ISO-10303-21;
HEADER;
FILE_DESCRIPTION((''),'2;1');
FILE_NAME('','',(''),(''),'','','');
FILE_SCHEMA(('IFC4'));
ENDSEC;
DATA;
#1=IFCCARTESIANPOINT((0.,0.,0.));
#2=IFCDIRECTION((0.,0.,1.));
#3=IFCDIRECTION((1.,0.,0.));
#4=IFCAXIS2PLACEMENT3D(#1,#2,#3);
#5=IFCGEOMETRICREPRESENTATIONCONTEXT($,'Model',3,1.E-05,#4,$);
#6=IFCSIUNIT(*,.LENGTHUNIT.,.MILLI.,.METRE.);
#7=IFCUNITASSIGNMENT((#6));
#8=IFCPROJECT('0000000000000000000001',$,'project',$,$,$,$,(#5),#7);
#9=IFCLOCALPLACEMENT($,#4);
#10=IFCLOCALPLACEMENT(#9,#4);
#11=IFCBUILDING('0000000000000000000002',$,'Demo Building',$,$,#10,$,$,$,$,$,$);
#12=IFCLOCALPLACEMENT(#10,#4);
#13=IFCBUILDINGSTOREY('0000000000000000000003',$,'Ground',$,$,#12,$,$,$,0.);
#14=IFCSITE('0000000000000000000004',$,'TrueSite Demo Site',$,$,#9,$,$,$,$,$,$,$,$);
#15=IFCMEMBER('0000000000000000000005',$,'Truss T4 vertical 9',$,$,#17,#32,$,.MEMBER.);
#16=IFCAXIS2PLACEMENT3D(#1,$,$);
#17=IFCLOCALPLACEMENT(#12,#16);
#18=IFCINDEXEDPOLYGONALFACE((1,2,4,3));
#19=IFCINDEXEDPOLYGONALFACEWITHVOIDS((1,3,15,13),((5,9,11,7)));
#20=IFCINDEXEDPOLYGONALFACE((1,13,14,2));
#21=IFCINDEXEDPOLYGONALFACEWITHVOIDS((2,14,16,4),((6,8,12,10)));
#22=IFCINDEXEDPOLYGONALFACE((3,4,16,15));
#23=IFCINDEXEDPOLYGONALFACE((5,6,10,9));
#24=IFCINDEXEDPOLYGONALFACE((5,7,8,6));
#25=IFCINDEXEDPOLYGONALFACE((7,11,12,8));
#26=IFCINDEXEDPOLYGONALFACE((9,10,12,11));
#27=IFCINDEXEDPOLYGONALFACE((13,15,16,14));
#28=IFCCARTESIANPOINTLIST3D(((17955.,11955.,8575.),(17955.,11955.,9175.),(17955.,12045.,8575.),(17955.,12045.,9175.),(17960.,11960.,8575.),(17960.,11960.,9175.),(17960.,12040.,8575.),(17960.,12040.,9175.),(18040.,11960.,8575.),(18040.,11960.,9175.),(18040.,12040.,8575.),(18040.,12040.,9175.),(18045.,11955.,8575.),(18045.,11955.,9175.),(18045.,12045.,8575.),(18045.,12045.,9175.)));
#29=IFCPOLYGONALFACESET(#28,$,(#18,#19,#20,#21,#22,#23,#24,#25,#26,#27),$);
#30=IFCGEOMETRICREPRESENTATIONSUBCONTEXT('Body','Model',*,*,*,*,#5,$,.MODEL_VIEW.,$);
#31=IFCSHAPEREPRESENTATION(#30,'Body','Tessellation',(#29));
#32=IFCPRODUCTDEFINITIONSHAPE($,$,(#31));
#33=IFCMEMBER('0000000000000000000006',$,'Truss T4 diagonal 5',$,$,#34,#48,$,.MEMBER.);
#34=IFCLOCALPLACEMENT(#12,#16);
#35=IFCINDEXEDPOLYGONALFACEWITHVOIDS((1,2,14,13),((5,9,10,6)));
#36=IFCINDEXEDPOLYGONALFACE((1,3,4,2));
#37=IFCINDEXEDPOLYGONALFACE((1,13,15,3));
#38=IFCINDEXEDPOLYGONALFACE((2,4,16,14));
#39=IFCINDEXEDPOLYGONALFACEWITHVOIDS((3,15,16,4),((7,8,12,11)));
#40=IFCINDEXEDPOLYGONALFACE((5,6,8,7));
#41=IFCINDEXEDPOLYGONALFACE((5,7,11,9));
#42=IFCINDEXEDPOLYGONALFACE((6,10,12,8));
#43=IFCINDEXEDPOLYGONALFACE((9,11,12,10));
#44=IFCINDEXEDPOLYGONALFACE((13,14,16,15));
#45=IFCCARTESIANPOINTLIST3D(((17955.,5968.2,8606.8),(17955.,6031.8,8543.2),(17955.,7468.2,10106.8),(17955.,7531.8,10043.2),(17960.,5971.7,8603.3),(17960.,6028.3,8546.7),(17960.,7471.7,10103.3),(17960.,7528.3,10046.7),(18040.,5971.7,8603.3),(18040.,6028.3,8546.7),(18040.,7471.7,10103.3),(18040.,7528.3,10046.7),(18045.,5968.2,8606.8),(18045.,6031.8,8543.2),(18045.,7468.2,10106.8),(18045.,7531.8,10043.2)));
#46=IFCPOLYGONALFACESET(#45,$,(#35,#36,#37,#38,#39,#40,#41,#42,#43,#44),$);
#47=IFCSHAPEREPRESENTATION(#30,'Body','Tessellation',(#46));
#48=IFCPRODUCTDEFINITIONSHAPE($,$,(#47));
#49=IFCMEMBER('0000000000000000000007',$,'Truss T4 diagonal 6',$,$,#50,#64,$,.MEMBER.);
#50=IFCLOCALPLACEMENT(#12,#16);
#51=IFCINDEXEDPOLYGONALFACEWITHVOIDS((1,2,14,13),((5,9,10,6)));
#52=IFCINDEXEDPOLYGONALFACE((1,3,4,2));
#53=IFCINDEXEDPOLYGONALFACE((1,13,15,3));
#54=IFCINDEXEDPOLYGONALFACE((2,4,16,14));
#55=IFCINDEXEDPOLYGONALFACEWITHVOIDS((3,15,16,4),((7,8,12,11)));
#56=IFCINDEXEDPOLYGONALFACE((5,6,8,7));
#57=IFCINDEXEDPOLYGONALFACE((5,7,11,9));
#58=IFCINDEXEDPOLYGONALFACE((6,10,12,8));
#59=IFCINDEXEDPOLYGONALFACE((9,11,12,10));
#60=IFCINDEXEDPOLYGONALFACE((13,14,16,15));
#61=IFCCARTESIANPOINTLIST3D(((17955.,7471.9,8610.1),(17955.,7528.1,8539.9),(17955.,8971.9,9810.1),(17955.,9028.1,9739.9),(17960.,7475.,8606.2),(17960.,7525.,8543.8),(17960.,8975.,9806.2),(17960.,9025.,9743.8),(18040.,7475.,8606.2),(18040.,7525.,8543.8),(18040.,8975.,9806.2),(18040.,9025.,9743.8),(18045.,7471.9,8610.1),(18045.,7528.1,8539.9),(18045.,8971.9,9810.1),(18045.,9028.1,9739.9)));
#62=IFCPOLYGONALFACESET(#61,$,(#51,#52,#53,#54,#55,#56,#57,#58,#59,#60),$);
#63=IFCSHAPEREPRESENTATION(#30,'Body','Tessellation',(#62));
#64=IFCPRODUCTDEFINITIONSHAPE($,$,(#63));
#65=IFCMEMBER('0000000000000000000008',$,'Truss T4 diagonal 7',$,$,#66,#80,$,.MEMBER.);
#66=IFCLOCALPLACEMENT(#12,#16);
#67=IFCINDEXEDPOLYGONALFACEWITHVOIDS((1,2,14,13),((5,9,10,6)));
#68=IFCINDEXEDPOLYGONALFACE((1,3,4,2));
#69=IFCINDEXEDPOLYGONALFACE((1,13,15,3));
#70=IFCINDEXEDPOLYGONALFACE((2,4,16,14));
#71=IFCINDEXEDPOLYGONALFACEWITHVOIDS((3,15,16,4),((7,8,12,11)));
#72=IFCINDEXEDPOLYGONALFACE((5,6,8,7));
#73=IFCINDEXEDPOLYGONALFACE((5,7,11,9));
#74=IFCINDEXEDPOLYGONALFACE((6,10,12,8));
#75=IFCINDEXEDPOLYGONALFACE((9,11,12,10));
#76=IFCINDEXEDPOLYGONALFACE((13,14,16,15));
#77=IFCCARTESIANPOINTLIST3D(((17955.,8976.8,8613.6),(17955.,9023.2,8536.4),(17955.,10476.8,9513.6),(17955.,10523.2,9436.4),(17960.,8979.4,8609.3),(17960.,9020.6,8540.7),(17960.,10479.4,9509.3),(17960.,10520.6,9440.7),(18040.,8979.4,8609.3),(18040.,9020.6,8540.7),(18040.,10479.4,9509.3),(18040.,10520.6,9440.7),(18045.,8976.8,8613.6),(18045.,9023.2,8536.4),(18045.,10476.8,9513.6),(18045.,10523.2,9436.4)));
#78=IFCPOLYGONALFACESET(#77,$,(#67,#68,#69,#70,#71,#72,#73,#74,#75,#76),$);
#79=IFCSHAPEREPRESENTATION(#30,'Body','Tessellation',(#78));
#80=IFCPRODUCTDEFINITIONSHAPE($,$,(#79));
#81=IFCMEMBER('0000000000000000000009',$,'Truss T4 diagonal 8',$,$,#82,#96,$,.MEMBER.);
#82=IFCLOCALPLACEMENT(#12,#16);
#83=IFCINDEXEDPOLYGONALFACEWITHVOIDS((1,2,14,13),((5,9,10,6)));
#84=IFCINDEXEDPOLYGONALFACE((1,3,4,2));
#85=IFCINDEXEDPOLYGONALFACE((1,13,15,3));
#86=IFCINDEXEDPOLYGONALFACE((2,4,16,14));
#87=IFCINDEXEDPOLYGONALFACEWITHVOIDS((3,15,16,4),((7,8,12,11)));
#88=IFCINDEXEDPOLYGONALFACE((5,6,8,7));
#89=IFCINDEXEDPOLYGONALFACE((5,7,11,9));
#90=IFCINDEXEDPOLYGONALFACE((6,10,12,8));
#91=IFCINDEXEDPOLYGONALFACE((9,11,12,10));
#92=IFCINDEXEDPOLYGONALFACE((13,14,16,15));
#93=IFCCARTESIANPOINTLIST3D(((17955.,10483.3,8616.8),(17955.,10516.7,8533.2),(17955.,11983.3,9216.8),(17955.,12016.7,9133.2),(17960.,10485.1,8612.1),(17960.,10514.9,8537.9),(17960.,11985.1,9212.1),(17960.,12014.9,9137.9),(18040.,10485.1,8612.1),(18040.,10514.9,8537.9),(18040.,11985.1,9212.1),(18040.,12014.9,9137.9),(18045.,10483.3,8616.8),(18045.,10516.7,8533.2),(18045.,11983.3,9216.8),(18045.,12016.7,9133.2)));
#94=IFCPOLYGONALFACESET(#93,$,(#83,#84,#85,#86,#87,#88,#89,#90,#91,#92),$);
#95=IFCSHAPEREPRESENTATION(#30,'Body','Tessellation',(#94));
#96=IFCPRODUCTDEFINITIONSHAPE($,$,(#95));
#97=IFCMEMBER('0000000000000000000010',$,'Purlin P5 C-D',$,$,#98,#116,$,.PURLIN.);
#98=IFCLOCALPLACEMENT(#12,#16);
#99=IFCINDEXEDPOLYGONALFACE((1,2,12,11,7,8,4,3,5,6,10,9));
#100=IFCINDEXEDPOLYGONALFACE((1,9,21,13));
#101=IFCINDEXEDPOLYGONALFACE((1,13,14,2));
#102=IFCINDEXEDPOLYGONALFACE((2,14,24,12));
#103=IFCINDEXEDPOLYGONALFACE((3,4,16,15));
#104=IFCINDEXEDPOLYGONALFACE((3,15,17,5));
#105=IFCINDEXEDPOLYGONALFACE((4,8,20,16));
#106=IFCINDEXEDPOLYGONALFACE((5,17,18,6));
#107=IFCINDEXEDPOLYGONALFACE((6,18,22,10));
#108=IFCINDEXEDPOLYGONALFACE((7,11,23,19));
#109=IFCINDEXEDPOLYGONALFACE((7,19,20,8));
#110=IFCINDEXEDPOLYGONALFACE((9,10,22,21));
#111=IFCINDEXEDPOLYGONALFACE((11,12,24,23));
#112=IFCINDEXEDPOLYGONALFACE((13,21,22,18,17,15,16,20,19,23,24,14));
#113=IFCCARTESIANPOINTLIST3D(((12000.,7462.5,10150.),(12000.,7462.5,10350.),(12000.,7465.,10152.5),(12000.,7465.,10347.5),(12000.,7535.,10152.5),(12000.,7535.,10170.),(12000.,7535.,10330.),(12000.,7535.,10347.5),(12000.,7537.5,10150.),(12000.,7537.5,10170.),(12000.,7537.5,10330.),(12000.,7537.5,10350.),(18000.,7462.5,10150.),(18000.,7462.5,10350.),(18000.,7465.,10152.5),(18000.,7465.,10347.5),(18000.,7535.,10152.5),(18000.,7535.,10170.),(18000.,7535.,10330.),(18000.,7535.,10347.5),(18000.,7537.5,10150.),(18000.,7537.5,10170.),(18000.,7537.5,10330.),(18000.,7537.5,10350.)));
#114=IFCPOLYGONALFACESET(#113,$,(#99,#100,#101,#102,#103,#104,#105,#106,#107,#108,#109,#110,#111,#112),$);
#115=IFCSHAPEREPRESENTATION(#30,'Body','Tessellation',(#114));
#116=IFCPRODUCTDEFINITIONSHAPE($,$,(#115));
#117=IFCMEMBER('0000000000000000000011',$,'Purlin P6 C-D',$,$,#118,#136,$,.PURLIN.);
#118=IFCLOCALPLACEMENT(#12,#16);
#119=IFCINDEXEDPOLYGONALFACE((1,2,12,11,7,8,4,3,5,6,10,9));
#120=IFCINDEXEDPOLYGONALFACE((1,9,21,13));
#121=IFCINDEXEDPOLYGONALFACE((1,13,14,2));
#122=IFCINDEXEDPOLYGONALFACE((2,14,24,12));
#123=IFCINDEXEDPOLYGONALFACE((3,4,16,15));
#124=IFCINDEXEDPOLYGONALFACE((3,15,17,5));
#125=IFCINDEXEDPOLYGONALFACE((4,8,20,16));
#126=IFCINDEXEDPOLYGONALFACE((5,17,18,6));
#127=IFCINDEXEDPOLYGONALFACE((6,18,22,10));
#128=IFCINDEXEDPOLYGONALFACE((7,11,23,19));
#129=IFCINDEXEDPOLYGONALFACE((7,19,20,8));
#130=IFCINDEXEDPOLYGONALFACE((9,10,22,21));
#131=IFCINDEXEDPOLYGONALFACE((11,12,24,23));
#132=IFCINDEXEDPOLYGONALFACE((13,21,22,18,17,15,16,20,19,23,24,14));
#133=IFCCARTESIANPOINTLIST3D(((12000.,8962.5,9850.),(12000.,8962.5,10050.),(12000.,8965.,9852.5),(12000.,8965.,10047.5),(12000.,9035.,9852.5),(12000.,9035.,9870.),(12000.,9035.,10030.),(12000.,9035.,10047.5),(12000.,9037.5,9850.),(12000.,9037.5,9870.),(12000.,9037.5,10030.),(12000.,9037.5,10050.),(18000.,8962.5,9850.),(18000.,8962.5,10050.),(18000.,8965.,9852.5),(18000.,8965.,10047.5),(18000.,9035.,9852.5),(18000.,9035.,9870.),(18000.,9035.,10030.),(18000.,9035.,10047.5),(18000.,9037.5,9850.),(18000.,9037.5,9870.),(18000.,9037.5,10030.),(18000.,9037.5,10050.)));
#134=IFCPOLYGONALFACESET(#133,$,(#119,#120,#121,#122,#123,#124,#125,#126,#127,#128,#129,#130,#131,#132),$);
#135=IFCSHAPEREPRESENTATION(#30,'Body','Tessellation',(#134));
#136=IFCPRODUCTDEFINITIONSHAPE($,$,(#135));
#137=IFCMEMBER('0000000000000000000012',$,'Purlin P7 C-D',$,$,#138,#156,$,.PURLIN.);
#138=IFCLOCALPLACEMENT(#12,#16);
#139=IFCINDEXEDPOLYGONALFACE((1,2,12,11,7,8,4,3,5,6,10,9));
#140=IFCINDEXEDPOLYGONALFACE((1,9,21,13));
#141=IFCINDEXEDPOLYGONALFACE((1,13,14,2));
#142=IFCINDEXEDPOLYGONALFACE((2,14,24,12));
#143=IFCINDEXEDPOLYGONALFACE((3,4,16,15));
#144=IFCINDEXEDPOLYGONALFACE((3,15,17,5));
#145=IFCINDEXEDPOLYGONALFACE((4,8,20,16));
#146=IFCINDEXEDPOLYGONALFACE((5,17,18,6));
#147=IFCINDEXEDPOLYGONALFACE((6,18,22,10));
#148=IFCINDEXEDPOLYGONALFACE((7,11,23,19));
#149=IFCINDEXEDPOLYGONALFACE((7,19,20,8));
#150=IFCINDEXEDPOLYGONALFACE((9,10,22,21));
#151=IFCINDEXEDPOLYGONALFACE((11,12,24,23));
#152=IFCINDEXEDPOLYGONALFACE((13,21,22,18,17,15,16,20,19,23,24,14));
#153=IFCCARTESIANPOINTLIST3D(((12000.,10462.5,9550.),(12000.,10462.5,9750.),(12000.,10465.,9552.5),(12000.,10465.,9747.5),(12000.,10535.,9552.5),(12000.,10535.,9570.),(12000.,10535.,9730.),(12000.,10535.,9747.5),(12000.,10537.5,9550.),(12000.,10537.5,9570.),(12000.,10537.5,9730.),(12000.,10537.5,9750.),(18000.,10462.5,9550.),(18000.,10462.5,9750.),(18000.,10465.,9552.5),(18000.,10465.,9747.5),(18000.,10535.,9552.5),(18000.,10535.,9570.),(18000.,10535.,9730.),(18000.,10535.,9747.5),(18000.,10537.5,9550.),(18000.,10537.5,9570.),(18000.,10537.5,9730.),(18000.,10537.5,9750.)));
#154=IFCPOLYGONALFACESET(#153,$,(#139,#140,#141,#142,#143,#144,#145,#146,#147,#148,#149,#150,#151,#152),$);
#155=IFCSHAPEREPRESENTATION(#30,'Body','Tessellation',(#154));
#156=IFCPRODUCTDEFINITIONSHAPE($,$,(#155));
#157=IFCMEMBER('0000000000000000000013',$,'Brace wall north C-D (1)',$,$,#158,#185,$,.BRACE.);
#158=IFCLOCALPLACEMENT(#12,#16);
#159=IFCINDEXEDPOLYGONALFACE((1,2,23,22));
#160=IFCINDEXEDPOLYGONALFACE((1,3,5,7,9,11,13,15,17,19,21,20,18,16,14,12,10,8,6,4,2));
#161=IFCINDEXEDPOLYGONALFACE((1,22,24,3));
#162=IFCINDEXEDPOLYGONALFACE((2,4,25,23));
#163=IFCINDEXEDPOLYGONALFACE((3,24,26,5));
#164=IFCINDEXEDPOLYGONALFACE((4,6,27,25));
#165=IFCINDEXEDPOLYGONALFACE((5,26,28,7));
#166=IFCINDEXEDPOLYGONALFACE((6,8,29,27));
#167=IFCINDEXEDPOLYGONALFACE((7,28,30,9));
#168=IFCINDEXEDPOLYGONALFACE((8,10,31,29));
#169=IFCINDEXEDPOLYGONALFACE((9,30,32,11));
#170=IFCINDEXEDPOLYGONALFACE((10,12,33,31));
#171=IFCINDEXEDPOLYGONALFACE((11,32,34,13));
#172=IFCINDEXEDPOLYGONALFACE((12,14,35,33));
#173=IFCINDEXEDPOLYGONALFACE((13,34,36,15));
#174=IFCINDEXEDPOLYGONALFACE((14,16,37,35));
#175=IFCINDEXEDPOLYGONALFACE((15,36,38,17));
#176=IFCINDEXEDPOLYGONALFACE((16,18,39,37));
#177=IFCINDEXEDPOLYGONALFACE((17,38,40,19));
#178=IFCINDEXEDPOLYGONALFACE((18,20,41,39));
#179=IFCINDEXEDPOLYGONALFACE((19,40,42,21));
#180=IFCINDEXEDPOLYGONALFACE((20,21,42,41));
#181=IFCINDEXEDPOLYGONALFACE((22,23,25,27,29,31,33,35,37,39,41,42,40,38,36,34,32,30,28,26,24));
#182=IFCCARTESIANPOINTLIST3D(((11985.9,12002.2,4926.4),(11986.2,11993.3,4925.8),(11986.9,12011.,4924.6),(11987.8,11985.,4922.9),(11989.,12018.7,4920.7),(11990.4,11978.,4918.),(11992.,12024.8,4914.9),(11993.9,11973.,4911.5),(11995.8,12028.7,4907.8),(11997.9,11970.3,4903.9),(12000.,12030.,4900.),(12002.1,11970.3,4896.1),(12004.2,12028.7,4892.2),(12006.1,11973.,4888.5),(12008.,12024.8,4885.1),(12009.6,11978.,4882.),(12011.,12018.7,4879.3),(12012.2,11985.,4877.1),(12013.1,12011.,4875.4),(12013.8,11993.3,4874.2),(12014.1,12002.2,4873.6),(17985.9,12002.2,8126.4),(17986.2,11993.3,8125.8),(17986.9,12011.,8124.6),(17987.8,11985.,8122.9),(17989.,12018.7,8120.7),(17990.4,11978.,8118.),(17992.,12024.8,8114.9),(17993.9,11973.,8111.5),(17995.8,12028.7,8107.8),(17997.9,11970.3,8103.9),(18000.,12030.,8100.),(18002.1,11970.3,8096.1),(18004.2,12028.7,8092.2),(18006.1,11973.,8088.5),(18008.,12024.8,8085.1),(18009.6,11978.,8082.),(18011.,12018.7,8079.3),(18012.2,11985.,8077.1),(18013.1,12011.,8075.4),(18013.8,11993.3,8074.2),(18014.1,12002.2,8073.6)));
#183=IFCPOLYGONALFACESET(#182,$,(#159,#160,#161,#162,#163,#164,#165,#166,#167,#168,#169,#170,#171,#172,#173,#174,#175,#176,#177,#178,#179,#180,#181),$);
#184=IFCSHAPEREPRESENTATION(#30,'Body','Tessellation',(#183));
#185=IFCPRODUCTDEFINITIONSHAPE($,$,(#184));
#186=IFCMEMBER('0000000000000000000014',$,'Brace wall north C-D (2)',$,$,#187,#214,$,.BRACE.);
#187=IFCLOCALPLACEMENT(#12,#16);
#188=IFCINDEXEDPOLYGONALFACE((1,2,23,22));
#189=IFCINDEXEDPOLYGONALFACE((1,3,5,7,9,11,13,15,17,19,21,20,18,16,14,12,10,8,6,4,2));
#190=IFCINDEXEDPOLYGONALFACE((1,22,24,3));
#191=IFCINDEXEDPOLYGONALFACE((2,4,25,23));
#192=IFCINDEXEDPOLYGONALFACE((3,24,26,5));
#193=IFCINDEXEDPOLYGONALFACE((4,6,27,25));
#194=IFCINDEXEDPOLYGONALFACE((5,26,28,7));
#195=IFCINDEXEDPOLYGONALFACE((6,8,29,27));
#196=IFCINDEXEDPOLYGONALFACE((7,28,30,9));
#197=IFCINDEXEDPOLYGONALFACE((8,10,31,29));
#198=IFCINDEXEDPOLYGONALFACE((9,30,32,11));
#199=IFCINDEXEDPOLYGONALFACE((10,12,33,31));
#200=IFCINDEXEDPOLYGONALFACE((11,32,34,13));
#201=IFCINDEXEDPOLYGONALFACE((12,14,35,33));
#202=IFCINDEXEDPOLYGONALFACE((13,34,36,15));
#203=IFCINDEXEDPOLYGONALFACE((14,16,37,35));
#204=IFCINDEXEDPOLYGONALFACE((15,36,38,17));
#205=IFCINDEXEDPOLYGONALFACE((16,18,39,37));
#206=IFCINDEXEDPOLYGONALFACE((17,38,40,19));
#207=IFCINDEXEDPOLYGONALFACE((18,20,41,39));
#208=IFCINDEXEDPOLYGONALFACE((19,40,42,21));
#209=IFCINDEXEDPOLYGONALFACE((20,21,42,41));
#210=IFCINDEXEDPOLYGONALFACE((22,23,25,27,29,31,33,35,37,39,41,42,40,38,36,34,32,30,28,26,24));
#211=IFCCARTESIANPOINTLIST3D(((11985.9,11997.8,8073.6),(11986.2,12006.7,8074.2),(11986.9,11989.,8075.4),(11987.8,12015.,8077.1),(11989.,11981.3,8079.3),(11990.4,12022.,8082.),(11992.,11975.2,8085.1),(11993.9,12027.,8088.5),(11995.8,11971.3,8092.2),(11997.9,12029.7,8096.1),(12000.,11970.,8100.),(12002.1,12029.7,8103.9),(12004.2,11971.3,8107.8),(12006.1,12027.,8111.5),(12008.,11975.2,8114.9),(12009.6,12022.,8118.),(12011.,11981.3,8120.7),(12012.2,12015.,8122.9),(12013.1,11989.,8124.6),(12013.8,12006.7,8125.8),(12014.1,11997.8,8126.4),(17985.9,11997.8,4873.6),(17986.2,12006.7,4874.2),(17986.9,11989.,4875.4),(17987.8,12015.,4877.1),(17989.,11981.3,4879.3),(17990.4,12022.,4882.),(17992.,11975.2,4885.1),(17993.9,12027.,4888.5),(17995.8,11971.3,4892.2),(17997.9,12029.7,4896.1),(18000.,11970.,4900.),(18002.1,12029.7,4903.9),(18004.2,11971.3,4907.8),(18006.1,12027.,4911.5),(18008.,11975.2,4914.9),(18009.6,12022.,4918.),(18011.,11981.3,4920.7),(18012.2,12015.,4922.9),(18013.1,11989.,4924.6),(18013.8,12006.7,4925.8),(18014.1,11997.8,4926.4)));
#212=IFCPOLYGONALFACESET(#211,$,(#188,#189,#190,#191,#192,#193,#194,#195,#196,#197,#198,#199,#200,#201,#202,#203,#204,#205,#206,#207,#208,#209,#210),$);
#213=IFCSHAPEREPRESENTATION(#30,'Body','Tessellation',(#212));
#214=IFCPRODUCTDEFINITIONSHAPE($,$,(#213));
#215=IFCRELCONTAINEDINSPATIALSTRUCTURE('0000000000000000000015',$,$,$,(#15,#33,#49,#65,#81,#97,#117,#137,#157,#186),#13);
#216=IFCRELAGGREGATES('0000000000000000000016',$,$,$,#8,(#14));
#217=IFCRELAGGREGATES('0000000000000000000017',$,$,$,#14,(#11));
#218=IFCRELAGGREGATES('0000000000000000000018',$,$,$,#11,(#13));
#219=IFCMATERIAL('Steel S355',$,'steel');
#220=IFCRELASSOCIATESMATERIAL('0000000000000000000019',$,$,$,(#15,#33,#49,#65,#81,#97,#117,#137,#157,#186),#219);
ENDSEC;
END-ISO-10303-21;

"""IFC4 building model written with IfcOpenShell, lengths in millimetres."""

from ifc_helpers import new_model, si_unit, frame, origin_with_axes, place, context, subcontext, project, spatial, hollow_rectangle, circle, c_section, extrude, material, element, save


model = new_model("IFC4")

# Units and contexts
model_context = context("Model", 3, precision=1e-05, world=origin_with_axes())
body_context = subcontext(model_context, "Body", "Model", "MODEL_VIEW")
ifc_project = project(units=[si_unit("LENGTHUNIT", "METRE", prefix="MILLI")], contexts=[model_context])

# Site, building, storey
site_placement = place(None, origin_with_axes())
site = spatial("IfcSite", under=ifc_project, at=site_placement, Name="TrueSite Demo Site")
building_placement = place(site_placement, origin_with_axes())
building = spatial("IfcBuilding", under=site, at=building_placement, Name="Demo Building")
storey_placement = place(building_placement, origin_with_axes())
storey = spatial("IfcBuildingStorey", under=building, at=storey_placement, Name="Ground", Elevation=0.0)

# Shared definitions
ifc_material_1 = material(Name="Steel S355", Category="steel")

# Members
member_1_placement = place(storey_placement, frame((18000.0, 12000.0, 8575.0), z_axis=(0.0, 0.0, 1.0), x_axis=(1.0, 0.0, 0.0)))
element("IfcMember", 1, at=member_1_placement, inside=storey, material=ifc_material_1, Name="Truss T4 vertical 9", PredefinedType="MEMBER", context=body_context, shape_type="SweptSolid", body=[
    extrude(hollow_rectangle(XDim=90.0, YDim=90.0, WallThickness=5.0), origin_with_axes(), (0.0, 0.0, 1.0), 600.0),
])
member_2_placement = place(storey_placement, frame((18000.0, 6000.0, 8575.0), z_axis=(0.0, 0.707107, 0.707107), x_axis=(-1.0, 0.0, 0.0)))
element("IfcMember", 2, at=member_2_placement, inside=storey, material=ifc_material_1, Name="Truss T4 diagonal 5", PredefinedType="MEMBER", context=body_context, shape_type="SweptSolid", body=[
    extrude(hollow_rectangle(XDim=90.0, YDim=90.0, WallThickness=5.0), origin_with_axes(), (0.0, 0.0, 1.0), 2121.3),
])
member_3_placement = place(storey_placement, frame((18000.0, 7500.0, 8575.0), z_axis=(0.0, 0.780869, 0.624695), x_axis=(-1.0, 0.0, 0.0)))
element("IfcMember", 3, at=member_3_placement, inside=storey, material=ifc_material_1, Name="Truss T4 diagonal 6", PredefinedType="MEMBER", context=body_context, shape_type="SweptSolid", body=[
    extrude(hollow_rectangle(XDim=90.0, YDim=90.0, WallThickness=5.0), origin_with_axes(), (0.0, 0.0, 1.0), 1920.9),
])
member_4_placement = place(storey_placement, frame((18000.0, 9000.0, 8575.0), z_axis=(0.0, 0.857493, 0.514496), x_axis=(-1.0, 0.0, 0.0)))
element("IfcMember", 4, at=member_4_placement, inside=storey, material=ifc_material_1, Name="Truss T4 diagonal 7", PredefinedType="MEMBER", context=body_context, shape_type="SweptSolid", body=[
    extrude(hollow_rectangle(XDim=90.0, YDim=90.0, WallThickness=5.0), origin_with_axes(), (0.0, 0.0, 1.0), 1749.3),
])
member_5_placement = place(storey_placement, frame((18000.0, 10500.0, 8575.0), z_axis=(0.0, 0.928477, 0.371391), x_axis=(-1.0, 0.0, 0.0)))
element("IfcMember", 5, at=member_5_placement, inside=storey, material=ifc_material_1, Name="Truss T4 diagonal 8", PredefinedType="MEMBER", context=body_context, shape_type="SweptSolid", body=[
    extrude(hollow_rectangle(XDim=90.0, YDim=90.0, WallThickness=5.0), origin_with_axes(), (0.0, 0.0, 1.0), 1615.5),
])
for number, where, z_axis, x_axis, name in (
    (6, (12000.0, 7500.0, 10250.0), (1.0, 0.0, 0.0), (0.0, 1.0, 0.0), "Purlin P5 C-D"),
    (7, (12000.0, 9000.0, 9950.0), (1.0, 0.0, 0.0), (0.0, 1.0, 0.0), "Purlin P6 C-D"),
    (8, (12000.0, 10500.0, 9650.0), (1.0, 0.0, 0.0), (0.0, 1.0, 0.0), "Purlin P7 C-D"),
):
    element("IfcMember", number, at=place(storey_placement, frame(where, z_axis=z_axis, x_axis=x_axis)), inside=storey, material=ifc_material_1, Name=name, PredefinedType="PURLIN", context=body_context, shape_type="SweptSolid", body=[
        extrude(c_section(Depth=200.0, Width=75.0, WallThickness=2.5, Girth=20.0), origin_with_axes(), (0.0, 0.0, 1.0), 6000.0),
    ])
for number, where, z_axis, x_axis, name in (
    (9, (12000.0, 12000.0, 4900.0), (0.882353, 0.0, 0.470588), (0.0, 1.0, 0.0), "Brace wall north C-D (1)"),
    (10, (18000.0, 12000.0, 4900.0), (-0.882353, 0.0, 0.470588), (0.0, -1.0, 0.0), "Brace wall north C-D (2)"),
):
    element("IfcMember", number, at=place(storey_placement, frame(where, z_axis=z_axis, x_axis=x_axis)), inside=storey, material=ifc_material_1, Name=name, PredefinedType="BRACE", context=body_context, shape_type="SweptSolid", body=[
        extrude(circle(Radius=30.0), origin_with_axes(), (0.0, 0.0, 1.0), 6800.0),
    ])

save(model, "model.ifc")
